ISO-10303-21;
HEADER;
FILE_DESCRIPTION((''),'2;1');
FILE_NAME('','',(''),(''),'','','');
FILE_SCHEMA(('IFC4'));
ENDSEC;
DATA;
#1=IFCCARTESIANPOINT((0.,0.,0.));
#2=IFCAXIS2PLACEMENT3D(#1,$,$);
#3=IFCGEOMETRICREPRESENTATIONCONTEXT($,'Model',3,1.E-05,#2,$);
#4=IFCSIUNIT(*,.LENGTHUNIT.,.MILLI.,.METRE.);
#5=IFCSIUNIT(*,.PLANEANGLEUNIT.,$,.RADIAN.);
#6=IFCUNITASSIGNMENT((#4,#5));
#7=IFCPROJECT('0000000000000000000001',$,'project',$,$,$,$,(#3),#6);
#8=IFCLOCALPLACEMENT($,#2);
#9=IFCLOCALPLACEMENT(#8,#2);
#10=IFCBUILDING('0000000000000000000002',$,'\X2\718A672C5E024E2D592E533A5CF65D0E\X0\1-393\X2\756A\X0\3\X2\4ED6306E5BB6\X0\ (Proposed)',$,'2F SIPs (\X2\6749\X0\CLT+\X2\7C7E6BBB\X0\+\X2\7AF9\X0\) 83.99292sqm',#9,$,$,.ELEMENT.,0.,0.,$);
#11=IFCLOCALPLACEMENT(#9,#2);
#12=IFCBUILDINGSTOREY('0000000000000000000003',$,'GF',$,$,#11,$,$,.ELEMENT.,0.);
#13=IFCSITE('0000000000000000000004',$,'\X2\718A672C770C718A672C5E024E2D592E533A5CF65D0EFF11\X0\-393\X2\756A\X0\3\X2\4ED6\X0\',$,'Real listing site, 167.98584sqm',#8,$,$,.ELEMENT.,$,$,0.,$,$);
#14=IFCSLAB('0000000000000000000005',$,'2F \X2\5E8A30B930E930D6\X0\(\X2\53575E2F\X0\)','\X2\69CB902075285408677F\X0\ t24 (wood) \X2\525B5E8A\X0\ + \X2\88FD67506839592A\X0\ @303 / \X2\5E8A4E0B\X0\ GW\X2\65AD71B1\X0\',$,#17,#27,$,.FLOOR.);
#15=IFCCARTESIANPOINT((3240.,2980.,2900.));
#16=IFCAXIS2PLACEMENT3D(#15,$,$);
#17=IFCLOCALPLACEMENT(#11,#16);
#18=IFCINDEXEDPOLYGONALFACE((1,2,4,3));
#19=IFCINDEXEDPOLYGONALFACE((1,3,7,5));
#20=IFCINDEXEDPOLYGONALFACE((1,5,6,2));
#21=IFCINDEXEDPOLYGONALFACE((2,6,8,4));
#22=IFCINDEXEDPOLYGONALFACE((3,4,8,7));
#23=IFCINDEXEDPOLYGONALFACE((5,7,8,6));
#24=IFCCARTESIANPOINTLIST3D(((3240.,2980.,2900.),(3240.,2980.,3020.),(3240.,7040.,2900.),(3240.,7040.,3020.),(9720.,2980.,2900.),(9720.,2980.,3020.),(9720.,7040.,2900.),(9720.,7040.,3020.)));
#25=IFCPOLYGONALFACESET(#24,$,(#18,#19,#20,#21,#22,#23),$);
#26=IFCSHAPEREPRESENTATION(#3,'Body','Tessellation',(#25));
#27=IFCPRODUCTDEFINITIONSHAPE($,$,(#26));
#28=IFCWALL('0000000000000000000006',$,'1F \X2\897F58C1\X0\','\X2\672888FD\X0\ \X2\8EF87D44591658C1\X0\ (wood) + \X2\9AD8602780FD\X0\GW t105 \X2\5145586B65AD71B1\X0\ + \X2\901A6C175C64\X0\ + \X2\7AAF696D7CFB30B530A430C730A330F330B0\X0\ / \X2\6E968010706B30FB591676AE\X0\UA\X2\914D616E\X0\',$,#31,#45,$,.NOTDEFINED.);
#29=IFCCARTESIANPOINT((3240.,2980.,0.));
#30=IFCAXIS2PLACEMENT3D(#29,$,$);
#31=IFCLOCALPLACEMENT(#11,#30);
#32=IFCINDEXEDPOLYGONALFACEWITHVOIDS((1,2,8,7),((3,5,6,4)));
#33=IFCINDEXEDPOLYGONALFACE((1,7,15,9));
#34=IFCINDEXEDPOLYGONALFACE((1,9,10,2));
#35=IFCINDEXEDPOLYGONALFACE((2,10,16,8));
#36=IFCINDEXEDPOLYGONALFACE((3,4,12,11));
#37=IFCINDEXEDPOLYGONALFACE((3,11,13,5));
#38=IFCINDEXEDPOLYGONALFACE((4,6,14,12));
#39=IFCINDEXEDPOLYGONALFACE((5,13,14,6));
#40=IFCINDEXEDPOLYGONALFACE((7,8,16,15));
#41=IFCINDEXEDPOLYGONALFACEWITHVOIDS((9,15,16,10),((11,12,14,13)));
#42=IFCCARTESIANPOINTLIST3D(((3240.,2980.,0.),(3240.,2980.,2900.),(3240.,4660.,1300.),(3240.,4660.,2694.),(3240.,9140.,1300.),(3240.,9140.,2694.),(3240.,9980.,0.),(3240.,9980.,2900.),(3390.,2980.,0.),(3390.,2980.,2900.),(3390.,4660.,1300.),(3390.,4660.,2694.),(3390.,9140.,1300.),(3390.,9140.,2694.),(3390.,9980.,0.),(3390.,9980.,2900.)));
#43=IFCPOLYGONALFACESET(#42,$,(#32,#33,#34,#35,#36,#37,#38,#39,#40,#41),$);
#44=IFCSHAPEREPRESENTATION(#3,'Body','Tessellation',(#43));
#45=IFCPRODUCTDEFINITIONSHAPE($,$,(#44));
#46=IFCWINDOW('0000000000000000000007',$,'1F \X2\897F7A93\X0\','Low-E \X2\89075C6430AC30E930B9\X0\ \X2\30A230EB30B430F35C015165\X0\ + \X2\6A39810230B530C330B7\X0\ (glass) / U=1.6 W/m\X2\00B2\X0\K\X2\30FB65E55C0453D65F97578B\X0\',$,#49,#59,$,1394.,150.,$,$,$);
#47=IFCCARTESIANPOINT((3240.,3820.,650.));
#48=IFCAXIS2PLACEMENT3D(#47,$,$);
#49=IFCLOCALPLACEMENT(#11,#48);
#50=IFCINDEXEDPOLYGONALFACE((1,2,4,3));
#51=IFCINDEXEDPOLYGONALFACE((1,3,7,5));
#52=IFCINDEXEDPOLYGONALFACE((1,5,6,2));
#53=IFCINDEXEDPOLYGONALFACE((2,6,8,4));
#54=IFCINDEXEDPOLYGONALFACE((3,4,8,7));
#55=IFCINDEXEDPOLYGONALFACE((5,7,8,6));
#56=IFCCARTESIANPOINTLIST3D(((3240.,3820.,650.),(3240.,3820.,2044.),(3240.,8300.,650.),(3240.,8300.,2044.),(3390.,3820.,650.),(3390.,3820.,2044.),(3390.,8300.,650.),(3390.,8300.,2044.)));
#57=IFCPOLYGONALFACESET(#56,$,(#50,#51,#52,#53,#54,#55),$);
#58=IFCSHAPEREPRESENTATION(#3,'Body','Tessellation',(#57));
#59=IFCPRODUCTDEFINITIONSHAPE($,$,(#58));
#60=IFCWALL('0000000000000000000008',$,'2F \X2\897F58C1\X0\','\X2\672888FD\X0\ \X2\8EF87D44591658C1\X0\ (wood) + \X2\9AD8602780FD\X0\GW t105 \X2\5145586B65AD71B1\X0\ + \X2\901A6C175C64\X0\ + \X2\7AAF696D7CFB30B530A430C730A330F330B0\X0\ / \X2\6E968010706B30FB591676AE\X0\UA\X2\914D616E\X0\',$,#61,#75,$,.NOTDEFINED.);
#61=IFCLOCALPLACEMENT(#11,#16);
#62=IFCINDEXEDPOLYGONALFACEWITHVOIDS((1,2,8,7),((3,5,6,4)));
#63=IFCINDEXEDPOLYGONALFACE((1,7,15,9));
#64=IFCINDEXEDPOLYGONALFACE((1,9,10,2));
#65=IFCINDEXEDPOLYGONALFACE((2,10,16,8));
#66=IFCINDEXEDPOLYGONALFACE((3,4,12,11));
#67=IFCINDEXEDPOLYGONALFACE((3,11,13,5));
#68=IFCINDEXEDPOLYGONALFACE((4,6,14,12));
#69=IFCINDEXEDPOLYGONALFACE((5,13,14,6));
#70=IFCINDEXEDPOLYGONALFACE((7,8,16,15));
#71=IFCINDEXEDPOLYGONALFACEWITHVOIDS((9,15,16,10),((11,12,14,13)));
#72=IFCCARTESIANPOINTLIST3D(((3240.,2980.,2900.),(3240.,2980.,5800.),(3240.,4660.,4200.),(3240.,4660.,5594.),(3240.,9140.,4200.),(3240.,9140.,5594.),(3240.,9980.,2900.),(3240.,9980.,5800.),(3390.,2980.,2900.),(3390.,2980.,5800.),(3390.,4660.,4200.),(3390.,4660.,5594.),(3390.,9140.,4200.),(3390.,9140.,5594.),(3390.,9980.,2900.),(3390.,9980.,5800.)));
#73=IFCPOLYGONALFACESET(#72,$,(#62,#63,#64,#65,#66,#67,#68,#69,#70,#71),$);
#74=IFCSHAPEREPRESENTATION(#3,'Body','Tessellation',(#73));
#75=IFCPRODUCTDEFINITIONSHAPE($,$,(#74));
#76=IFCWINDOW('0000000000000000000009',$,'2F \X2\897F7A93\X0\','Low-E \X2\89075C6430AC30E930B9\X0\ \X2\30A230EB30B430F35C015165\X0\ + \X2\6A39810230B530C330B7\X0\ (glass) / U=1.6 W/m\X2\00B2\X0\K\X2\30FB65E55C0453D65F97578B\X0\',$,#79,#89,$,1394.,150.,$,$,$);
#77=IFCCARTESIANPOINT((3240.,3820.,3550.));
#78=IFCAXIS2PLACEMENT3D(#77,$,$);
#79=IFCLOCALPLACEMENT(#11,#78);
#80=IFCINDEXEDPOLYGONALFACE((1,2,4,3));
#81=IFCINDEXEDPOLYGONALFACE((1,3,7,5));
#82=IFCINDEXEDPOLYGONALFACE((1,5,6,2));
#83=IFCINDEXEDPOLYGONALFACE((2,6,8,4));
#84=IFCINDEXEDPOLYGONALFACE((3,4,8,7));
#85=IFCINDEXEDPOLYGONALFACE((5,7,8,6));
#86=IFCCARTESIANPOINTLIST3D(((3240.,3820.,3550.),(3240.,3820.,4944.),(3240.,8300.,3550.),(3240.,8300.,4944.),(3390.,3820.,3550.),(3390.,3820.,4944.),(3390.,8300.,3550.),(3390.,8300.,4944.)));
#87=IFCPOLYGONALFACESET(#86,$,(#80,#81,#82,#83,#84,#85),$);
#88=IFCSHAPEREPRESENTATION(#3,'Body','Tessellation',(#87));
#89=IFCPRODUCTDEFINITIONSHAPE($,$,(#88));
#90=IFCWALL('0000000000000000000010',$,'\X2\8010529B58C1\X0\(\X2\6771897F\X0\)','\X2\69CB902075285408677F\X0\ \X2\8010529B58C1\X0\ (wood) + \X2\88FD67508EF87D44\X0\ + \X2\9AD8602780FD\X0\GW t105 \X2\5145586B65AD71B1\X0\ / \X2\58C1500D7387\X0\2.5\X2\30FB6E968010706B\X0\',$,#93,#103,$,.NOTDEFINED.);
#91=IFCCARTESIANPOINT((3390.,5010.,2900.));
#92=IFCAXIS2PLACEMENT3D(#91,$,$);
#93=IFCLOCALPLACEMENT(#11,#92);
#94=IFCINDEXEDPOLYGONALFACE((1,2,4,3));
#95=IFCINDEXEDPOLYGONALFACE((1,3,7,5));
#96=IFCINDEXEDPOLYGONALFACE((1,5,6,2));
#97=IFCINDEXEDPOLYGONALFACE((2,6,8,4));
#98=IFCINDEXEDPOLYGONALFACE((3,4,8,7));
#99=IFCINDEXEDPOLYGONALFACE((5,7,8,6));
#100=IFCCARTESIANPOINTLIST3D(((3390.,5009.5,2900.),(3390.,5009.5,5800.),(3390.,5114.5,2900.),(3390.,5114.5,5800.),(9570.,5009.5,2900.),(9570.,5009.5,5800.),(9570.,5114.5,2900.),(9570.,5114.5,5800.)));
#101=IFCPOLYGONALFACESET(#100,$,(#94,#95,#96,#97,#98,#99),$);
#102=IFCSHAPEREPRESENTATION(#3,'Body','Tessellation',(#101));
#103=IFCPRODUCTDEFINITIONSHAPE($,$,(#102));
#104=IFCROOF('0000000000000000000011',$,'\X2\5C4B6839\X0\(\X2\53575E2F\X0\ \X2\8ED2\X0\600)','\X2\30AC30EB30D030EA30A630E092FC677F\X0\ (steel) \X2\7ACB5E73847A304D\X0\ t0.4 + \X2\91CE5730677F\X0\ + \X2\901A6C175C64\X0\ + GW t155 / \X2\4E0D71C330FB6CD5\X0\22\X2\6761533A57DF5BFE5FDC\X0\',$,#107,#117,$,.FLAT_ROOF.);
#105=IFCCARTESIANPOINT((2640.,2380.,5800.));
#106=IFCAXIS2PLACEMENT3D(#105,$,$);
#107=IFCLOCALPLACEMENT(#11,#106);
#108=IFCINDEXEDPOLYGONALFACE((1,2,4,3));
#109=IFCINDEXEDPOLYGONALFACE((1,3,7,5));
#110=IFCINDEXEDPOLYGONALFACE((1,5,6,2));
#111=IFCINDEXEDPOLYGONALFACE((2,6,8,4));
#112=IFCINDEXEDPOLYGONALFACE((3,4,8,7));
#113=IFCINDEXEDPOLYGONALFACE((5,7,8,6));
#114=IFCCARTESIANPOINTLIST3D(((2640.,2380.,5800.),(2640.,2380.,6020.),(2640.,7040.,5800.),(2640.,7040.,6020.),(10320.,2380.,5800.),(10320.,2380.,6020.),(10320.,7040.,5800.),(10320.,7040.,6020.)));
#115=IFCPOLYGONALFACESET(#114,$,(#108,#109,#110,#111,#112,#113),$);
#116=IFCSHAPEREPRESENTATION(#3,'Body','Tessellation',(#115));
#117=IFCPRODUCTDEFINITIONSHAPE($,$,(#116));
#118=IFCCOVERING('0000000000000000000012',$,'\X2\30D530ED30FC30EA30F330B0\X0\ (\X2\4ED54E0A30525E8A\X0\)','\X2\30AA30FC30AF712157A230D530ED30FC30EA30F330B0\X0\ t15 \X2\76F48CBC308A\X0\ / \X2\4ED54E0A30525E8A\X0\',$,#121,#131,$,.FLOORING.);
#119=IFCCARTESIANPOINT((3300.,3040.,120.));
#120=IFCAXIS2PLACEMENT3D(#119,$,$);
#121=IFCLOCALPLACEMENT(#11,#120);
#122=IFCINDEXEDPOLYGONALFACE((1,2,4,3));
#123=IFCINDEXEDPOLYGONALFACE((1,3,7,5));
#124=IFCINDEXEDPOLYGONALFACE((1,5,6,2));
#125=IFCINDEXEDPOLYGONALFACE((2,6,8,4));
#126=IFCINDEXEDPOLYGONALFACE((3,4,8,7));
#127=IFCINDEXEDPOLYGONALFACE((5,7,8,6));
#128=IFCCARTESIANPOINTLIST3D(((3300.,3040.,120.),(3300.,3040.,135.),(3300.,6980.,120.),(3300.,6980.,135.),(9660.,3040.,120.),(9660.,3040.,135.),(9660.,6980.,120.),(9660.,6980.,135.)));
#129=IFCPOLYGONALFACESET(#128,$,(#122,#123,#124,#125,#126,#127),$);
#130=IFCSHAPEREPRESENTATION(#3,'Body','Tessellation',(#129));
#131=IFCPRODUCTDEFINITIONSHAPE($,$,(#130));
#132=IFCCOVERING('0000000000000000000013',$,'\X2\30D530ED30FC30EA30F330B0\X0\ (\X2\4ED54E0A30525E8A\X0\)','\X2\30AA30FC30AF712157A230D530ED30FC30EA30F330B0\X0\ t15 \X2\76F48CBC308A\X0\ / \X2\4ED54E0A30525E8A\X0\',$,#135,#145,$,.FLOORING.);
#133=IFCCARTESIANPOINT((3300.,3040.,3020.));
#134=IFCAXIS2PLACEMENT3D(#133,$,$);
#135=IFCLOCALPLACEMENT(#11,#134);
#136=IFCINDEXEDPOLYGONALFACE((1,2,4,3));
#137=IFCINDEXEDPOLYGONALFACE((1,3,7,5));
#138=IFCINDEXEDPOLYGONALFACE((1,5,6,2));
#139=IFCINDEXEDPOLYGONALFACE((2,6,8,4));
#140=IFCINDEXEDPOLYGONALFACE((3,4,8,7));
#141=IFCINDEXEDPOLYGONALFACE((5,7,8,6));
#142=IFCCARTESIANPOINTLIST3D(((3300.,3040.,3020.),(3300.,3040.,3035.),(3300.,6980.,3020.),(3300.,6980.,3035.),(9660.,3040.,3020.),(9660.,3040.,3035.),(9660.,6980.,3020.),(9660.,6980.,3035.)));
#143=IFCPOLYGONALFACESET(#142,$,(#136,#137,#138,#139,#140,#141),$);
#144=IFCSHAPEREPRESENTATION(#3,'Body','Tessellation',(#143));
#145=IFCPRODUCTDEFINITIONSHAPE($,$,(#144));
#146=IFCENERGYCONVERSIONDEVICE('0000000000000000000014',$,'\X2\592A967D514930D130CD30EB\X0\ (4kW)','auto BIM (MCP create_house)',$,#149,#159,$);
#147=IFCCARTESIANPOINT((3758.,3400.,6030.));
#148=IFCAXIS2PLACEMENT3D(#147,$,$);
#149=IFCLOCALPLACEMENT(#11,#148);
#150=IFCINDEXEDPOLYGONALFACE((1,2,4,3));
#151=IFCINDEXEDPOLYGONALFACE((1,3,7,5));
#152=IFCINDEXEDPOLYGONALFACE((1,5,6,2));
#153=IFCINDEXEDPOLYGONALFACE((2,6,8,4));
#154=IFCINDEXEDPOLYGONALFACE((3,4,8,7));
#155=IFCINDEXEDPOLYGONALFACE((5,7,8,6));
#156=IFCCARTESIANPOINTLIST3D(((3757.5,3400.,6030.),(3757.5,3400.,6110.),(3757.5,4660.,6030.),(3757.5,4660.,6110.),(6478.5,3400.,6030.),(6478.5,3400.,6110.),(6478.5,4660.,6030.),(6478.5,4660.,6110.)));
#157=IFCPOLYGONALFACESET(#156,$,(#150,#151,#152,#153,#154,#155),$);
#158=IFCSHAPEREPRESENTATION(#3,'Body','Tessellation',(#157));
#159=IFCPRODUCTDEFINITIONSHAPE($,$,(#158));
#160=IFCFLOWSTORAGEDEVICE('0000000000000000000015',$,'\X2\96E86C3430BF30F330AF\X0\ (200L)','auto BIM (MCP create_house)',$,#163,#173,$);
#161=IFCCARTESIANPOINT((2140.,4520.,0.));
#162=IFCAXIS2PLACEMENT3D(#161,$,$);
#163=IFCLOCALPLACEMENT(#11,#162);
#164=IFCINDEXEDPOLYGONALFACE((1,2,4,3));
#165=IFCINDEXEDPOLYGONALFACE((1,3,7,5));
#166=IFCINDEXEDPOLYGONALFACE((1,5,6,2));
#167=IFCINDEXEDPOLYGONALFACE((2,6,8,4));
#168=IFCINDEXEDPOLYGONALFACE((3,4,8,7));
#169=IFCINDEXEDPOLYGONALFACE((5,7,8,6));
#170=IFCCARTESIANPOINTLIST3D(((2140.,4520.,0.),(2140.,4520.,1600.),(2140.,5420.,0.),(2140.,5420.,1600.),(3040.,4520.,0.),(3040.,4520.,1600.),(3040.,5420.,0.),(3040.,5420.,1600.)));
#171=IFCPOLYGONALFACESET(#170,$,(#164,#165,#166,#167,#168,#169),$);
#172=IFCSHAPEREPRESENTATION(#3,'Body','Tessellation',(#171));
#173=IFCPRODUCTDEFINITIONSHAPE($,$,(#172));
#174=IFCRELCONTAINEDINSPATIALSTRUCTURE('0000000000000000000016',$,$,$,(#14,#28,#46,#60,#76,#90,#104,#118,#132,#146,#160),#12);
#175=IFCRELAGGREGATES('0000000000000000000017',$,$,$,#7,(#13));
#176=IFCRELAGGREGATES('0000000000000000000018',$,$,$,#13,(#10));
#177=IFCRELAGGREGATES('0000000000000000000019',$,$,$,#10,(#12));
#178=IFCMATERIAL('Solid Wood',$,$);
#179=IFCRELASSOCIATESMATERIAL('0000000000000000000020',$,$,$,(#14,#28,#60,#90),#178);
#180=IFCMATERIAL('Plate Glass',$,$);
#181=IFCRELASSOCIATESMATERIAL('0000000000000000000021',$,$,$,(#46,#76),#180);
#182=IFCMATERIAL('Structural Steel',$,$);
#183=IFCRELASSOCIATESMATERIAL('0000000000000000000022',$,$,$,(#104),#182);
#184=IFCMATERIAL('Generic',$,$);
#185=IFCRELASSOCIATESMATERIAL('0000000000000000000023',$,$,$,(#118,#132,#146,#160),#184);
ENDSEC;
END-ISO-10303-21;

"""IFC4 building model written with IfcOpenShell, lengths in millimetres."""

from ifc_helpers import new_model, si_unit, frame, frame_2d, origin, place, context, project, spatial, rectangle, extrude, material, element, fill, save


model = new_model("IFC4")

# Units and contexts
model_context = context("Model", 3, precision=1e-05, world=origin())
ifc_project = project(units=[si_unit("LENGTHUNIT", "METRE", prefix="MILLI"), si_unit("PLANEANGLEUNIT", "RADIAN")], contexts=[model_context])

# Site, building, storey
site_placement = place(None, origin())
site = spatial("IfcSite", under=ifc_project, at=site_placement, Name="熊本県熊本市中央区島崎１-393番3他", ObjectType="Real listing site, 167.98584sqm", CompositionType="ELEMENT", RefElevation=0.0)
building_placement = place(site_placement, origin())
building = spatial("IfcBuilding", under=site, at=building_placement, Name="熊本市中央区島崎1-393番3他の家 (Proposed)", ObjectType="2F SIPs (杉CLT+籾殻+竹) 83.99292sqm", CompositionType="ELEMENT", ElevationOfRefHeight=0.0, ElevationOfTerrain=0.0)
storey_placement = place(building_placement, origin())
storey = spatial("IfcBuildingStorey", under=building, at=storey_placement, Name="GF", CompositionType="ELEMENT", Elevation=0.0)

# Slab
ifc_material_1 = material(Name="Solid Wood")
slab_1_placement = place(storey_placement, frame((3240.0, 2980.0, 2900.0)))
element("IfcSlab", 1, at=slab_1_placement, inside=storey, material=ifc_material_1, Name="2F 床スラブ(南帯)", Description="構造用合板 t24 (wood) 剛床 + 製材根太 @303 / 床下 GW断熱", PredefinedType="FLOOR", context=model_context, shape_type="SweptSolid", body=[
    extrude(rectangle(XDim=6480.0, YDim=4060.0, at=frame_2d((3240.0, 2030.0))), frame((3240.0, 2980.0, 2900.0)), (0.0, 0.0, 1.0), 120.0),
])

# Shared definitions
ifc_material_2 = material(Name="Plate Glass")

# Wall, opening, window
wall_1_placement = place(storey_placement, frame((3240.0, 2980.0, 0.0)))
wall_1 = element("IfcWall", 2, at=wall_1_placement, inside=storey, material=ifc_material_1, Name="1F 西壁", Description="木製 軸組外壁 (wood) + 高性能GW t105 充填断熱 + 通気層 + 窯業系サイディング / 準耐火・外皮UA配慮", PredefinedType="NOTDEFINED", context=model_context, shape_type="SweptSolid", body=[
    extrude(rectangle(XDim=150.0, YDim=7000.0, at=frame_2d((75.0, 3500.0))), frame((3240.0, 2980.0, 0.0)), (0.0, 0.0, 1.0), 2900.0),
])
opening_1_placement = place(storey_placement, frame((3240.0, 3820.0, 650.0)))
opening_1 = element("IfcOpeningElement", 3, at=opening_1_placement, cuts=wall_1, PredefinedType="NOTDEFINED", context=model_context, shape_type="SweptSolid", body=[
    extrude(rectangle(XDim=150.0, YDim=4480.0, at=frame_2d((75.0, 2240.0))), frame((3240.0, 3820.0, 650.0)), (0.0, 0.0, 1.0), 1394.0),
])
window_1_placement = place(storey_placement, frame((3240.0, 3820.0, 650.0)))
window_1 = element("IfcWindow", 4, at=window_1_placement, inside=storey, material=ifc_material_2, Name="1F 西窓", Description="Low-E 複層ガラス アルゴン封入 + 樹脂サッシ (glass) / U=1.6 W/m²K・日射取得型", OverallHeight=1394.0, OverallWidth=150.0, context=model_context, shape_type="SweptSolid", body=[
    extrude(rectangle(XDim=150.0, YDim=4480.0, at=frame_2d((75.0, 2240.0))), frame((3240.0, 3820.0, 650.0)), (0.0, 0.0, 1.0), 1394.0),
])
fill(opening_1, window_1)

# Wall, opening, window
wall_2_placement = place(storey_placement, frame((3240.0, 2980.0, 2900.0)))
wall_2 = element("IfcWall", 5, at=wall_2_placement, inside=storey, material=ifc_material_1, Name="2F 西壁", Description="木製 軸組外壁 (wood) + 高性能GW t105 充填断熱 + 通気層 + 窯業系サイディング / 準耐火・外皮UA配慮", PredefinedType="NOTDEFINED", context=model_context, shape_type="SweptSolid", body=[
    extrude(rectangle(XDim=150.0, YDim=7000.0, at=frame_2d((75.0, 3500.0))), frame((3240.0, 2980.0, 2900.0)), (0.0, 0.0, 1.0), 2900.0),
])
opening_2_placement = place(storey_placement, frame((3240.0, 3820.0, 3550.0)))
opening_2 = element("IfcOpeningElement", 6, at=opening_2_placement, cuts=wall_2, PredefinedType="NOTDEFINED", context=model_context, shape_type="SweptSolid", body=[
    extrude(rectangle(XDim=150.0, YDim=4480.0, at=frame_2d((75.0, 2240.0))), frame((3240.0, 3820.0, 3550.0)), (0.0, 0.0, 1.0), 1394.0),
])
window_2_placement = place(storey_placement, frame((3240.0, 3820.0, 3550.0)))
window_2 = element("IfcWindow", 7, at=window_2_placement, inside=storey, material=ifc_material_2, Name="2F 西窓", Description="Low-E 複層ガラス アルゴン封入 + 樹脂サッシ (glass) / U=1.6 W/m²K・日射取得型", OverallHeight=1394.0, OverallWidth=150.0, context=model_context, shape_type="SweptSolid", body=[
    extrude(rectangle(XDim=150.0, YDim=4480.0, at=frame_2d((75.0, 2240.0))), frame((3240.0, 3820.0, 3550.0)), (0.0, 0.0, 1.0), 1394.0),
])
fill(opening_2, window_2)

# Wall
wall_3_placement = place(storey_placement, frame((3390.0, 5010.0, 2900.0)))
element("IfcWall", 8, at=wall_3_placement, inside=storey, material=ifc_material_1, Name="耐力壁(東西)", Description="構造用合板 耐力壁 (wood) + 製材軸組 + 高性能GW t105 充填断熱 / 壁倍率2.5・準耐火", PredefinedType="NOTDEFINED", context=model_context, shape_type="SweptSolid", body=[
    extrude(rectangle(XDim=6180.0, YDim=105.0, at=frame_2d((3090.0, 52.0))), frame((3390.0, 5010.0, 2900.0)), (0.0, 0.0, 1.0), 2900.0),
])

# Roof
ifc_material_3 = material(Name="Structural Steel")
for number, where, name in (
    (9, (2640.0, 2380.0, 5800.0), "屋根(南帯 軒600)"),
):
    element("IfcRoof", number, at=place(storey_placement, frame(where)), inside=storey, material=ifc_material_3, Name=name, Description="ガルバリウム鋼板 (steel) 立平葺き t0.4 + 野地板 + 通気層 + GW t155 / 不燃・法22条区域対応", PredefinedType="FLAT_ROOF", context=model_context, shape_type="SweptSolid", body=[
        extrude(rectangle(XDim=7680.0, YDim=4660.0, at=frame_2d((3840.0, 2330.0))), frame((2640.0, 2380.0, 5800.0)), (0.0, 0.0, 1.0), 220.0),
    ])

# Coverings
ifc_material_4 = material(Name="Generic")
covering_1_placement = place(storey_placement, frame((3300.0, 3040.0, 120.0)))
element("IfcCovering", 10, at=covering_1_placement, inside=storey, material=ifc_material_4, Name="フローリング (仕上げ床)", Description="オーク無垢フローリング t15 直貼り / 仕上げ床", PredefinedType="FLOORING", context=model_context, shape_type="SweptSolid", body=[
    extrude(rectangle(XDim=6360.0, YDim=3940.0, at=frame_2d((3180.0, 1970.0))), frame((3300.0, 3040.0, 120.0)), (0.0, 0.0, 1.0), 15.0),
])
covering_2_placement = place(storey_placement, frame((3300.0, 3040.0, 3020.0)))
element("IfcCovering", 11, at=covering_2_placement, inside=storey, material=ifc_material_4, Name="フローリング (仕上げ床)", Description="オーク無垢フローリング t15 直貼り / 仕上げ床", PredefinedType="FLOORING", context=model_context, shape_type="SweptSolid", body=[
    extrude(rectangle(XDim=6360.0, YDim=3940.0, at=frame_2d((3180.0, 1970.0))), frame((3300.0, 3040.0, 3020.0)), (0.0, 0.0, 1.0), 15.0),
])

# Energy conversion device
energy_conversion_device_placement = place(storey_placement, frame((3758.0, 3400.0, 6030.0)))
element("IfcEnergyConversionDevice", 12, at=energy_conversion_device_placement, inside=storey, material=ifc_material_4, Name="太陽光パネル (4kW)", Description="auto BIM (MCP create_house)", context=model_context, shape_type="SweptSolid", body=[
    extrude(rectangle(XDim=2721.0, YDim=1260.0, at=frame_2d((1360.0, 630.0))), frame((3758.0, 3400.0, 6030.0)), (0.0, 0.0, 1.0), 80.0),
])

# Flow storage device
flow_storage_device_placement = place(storey_placement, frame((2140.0, 4520.0, 0.0)))
element("IfcFlowStorageDevice", 13, at=flow_storage_device_placement, inside=storey, material=ifc_material_4, Name="雨水タンク (200L)", Description="auto BIM (MCP create_house)", context=model_context, shape_type="SweptSolid", body=[
    extrude(rectangle(XDim=900.0, YDim=900.0, at=frame_2d((450.0, 450.0))), frame((2140.0, 4520.0, 0.0)), (0.0, 0.0, 1.0), 1600.0),
])

save(model, "model.ifc")
